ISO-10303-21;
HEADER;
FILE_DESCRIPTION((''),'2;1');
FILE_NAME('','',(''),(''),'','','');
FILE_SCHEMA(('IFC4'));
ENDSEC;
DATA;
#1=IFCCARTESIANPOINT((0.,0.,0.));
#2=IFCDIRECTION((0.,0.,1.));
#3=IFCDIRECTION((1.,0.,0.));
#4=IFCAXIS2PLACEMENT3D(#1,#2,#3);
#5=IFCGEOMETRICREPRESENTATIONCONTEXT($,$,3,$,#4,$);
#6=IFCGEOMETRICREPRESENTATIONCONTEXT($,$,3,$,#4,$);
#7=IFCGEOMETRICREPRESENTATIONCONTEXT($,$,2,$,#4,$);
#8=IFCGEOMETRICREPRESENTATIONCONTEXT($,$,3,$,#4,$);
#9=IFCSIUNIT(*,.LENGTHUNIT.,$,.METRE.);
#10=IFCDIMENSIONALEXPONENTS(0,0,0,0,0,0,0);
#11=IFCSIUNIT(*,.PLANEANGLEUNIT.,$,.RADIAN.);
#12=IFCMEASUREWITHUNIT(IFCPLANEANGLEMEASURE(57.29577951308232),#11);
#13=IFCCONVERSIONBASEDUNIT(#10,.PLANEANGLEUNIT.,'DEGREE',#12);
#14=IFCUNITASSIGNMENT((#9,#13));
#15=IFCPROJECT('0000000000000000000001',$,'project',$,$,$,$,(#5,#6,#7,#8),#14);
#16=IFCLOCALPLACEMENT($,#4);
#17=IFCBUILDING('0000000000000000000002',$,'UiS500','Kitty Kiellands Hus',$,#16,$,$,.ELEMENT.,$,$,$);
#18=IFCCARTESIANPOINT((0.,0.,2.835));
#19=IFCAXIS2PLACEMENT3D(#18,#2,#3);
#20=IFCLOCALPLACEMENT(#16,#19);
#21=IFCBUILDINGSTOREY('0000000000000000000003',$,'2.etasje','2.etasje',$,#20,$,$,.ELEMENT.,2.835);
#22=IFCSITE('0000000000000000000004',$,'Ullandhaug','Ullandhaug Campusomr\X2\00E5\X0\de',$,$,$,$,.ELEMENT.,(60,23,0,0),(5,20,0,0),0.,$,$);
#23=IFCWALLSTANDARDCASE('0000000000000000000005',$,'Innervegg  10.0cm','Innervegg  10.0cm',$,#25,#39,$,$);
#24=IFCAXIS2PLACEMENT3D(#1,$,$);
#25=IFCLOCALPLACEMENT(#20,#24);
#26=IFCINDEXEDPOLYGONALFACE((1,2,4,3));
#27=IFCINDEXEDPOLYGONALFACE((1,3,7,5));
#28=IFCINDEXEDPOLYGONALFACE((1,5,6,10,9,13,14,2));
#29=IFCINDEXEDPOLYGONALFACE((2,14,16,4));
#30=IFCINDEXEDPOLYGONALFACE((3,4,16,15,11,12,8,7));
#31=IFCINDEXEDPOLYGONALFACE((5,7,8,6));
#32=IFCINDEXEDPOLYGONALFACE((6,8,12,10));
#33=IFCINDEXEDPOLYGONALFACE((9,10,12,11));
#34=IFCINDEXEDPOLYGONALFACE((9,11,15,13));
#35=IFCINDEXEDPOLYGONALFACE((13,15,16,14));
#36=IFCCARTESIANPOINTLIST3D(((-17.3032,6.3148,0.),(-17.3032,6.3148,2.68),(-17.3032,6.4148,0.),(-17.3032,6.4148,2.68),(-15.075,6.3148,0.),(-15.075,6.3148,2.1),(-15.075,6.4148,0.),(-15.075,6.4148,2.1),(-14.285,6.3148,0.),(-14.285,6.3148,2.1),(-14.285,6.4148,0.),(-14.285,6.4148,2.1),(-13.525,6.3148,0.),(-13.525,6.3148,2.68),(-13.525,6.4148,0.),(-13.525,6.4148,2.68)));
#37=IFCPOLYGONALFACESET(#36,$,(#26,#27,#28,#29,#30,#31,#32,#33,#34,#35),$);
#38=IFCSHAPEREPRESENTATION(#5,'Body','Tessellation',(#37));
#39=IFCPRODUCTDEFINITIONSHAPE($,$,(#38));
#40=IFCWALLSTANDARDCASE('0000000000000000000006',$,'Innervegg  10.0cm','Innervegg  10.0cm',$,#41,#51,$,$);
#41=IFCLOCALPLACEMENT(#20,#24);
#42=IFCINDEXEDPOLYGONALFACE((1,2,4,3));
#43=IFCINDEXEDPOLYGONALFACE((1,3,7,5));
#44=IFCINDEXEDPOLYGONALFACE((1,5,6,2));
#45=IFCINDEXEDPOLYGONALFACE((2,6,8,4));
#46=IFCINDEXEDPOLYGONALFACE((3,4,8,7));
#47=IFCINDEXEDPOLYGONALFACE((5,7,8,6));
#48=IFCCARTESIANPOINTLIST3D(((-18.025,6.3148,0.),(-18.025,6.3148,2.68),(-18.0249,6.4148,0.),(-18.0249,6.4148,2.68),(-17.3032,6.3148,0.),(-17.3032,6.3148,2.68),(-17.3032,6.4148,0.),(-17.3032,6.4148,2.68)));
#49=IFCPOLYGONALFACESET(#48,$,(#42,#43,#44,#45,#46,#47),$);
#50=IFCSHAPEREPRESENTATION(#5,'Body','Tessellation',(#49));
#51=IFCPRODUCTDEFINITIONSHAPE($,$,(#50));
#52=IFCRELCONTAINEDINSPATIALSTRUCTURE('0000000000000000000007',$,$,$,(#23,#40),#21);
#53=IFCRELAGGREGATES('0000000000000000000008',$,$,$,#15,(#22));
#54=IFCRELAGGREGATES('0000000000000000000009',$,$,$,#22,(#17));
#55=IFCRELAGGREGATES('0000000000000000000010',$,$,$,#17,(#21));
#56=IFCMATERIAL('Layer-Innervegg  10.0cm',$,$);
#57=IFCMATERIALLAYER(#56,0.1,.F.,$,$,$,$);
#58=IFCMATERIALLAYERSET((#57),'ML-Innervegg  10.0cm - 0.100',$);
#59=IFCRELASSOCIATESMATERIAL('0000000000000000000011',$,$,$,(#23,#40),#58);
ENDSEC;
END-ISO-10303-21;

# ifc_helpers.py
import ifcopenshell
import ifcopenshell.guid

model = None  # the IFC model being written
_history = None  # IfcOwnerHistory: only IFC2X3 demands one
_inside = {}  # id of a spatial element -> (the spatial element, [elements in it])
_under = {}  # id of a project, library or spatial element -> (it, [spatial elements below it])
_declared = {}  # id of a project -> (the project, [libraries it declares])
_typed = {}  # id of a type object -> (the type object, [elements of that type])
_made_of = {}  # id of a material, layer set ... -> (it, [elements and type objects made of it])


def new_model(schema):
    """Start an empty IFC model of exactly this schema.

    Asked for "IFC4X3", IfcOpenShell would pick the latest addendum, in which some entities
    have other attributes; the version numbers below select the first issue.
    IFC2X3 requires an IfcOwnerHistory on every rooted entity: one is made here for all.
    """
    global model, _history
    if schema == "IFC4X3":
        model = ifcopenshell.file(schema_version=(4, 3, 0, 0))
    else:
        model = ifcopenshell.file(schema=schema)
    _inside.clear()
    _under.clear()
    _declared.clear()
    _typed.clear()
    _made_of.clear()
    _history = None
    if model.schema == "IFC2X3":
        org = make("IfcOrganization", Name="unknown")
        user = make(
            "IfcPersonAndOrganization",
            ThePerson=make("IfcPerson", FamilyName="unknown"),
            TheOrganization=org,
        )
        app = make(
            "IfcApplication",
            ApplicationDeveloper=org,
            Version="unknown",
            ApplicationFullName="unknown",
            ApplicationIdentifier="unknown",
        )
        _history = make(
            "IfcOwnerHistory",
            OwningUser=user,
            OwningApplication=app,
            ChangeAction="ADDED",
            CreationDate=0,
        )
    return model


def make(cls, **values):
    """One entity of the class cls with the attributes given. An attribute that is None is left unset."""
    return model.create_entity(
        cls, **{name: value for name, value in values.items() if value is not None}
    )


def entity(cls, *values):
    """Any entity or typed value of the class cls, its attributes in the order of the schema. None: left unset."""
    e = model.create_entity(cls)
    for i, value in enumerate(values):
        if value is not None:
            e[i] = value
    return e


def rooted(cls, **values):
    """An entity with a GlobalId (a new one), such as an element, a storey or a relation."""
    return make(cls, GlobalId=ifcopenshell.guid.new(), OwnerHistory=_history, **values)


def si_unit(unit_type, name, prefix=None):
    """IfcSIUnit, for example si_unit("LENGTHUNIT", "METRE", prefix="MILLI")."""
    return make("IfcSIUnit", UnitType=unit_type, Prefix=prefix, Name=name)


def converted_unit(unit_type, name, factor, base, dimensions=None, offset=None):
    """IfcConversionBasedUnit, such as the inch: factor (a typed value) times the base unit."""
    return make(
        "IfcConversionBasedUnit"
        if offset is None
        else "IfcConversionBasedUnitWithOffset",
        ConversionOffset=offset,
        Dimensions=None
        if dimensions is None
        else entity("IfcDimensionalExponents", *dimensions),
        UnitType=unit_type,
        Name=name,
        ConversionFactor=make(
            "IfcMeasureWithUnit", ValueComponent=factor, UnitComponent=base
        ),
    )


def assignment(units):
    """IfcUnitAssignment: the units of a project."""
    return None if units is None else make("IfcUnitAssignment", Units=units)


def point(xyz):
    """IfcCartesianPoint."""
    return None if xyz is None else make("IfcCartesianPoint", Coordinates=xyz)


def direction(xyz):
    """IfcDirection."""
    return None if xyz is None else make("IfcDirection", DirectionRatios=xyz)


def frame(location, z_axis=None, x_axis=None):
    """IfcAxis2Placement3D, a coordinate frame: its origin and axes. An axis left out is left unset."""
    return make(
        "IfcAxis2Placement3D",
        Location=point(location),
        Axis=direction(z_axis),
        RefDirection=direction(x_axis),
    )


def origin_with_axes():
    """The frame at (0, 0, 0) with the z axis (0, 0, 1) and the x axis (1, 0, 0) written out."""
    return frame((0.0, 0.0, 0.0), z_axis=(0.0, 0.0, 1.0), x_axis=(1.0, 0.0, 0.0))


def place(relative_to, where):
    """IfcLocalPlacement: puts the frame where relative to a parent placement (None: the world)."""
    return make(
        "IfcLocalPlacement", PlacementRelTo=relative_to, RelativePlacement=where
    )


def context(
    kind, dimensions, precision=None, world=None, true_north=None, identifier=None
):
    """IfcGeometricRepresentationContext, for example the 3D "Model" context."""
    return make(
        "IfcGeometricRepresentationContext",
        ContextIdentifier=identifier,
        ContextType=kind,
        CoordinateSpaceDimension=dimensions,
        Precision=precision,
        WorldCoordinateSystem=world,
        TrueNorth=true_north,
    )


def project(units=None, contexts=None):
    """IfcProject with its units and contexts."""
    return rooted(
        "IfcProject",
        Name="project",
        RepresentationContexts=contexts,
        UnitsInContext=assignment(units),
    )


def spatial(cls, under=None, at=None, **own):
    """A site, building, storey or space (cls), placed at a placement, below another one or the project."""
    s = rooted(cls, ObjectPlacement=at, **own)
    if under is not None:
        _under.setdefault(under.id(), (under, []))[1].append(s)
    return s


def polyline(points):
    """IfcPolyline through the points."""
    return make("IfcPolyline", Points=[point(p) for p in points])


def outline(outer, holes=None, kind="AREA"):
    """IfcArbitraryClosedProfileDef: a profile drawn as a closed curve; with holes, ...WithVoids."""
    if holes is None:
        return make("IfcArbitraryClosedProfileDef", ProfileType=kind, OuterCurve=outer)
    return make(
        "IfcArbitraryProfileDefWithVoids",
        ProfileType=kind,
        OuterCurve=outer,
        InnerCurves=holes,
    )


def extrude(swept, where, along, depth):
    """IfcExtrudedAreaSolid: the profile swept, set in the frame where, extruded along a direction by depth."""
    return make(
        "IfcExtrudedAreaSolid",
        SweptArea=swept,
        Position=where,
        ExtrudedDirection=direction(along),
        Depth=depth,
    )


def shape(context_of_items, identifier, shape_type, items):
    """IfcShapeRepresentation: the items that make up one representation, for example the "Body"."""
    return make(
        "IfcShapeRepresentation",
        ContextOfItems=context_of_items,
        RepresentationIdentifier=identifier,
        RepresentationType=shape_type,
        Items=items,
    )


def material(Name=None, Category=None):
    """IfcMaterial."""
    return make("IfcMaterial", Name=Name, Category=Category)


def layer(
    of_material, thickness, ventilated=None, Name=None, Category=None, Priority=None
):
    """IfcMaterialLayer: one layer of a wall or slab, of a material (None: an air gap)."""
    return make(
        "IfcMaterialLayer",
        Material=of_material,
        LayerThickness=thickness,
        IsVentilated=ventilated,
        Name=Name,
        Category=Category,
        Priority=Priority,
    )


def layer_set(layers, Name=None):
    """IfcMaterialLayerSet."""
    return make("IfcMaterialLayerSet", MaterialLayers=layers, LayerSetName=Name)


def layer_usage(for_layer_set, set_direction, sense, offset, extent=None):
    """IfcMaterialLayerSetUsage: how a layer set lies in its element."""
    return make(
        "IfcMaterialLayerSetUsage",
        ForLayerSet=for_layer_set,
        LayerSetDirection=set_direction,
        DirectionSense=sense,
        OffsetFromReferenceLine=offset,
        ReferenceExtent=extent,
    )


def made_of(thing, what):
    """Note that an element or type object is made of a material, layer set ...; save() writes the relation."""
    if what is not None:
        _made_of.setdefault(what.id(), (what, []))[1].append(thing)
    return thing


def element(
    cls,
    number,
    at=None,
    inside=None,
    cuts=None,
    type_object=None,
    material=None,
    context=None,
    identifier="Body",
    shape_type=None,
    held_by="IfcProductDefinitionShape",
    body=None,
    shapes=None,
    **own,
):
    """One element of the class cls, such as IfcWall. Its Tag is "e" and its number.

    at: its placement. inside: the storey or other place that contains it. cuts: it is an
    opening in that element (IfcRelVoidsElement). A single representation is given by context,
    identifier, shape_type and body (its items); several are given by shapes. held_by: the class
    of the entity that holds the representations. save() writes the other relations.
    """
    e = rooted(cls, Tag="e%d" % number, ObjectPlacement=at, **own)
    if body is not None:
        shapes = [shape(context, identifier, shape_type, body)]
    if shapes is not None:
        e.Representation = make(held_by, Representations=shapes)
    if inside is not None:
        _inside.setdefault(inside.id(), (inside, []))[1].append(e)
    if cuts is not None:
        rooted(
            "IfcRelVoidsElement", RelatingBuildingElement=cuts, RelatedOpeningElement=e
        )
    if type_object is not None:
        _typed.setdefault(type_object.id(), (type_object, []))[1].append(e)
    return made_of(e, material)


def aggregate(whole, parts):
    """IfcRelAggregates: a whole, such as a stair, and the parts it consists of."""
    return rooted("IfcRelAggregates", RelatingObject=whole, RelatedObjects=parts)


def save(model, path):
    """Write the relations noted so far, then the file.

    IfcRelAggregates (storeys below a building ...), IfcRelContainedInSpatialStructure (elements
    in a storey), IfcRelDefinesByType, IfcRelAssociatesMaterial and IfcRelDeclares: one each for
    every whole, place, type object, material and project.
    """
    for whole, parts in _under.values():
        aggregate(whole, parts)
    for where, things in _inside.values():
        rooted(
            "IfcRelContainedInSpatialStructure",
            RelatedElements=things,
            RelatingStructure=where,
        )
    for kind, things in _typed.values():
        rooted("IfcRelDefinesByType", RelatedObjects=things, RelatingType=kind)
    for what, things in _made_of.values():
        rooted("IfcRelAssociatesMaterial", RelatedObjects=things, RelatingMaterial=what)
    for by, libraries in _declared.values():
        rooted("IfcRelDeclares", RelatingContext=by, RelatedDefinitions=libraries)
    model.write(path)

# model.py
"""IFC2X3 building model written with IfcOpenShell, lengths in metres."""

from ifc_helpers import new_model, entity, si_unit, converted_unit, frame, origin_with_axes, place, context, project, spatial, polyline, outline, extrude, material, layer, layer_set, layer_usage, element, save


model = new_model("IFC2X3")

# Units and contexts
context_of_model_1 = context(None, 3, world=origin_with_axes())
context_of_model_2 = context(None, 3, world=origin_with_axes())
context_of_model_3 = context(None, 2, world=origin_with_axes())
context_of_model_4 = context(None, 3, world=origin_with_axes())
ifc_project = project(units=[si_unit("LENGTHUNIT", "METRE"), converted_unit("PLANEANGLEUNIT", "DEGREE", entity("IfcPlaneAngleMeasure", 57.29577951308232), si_unit("PLANEANGLEUNIT", "RADIAN"), dimensions=[0, 0, 0, 0, 0, 0, 0])], contexts=[context_of_model_1, context_of_model_2, context_of_model_3, context_of_model_4])

# Site, building, storey
site = spatial("IfcSite", under=ifc_project, Name="Ullandhaug", Description="Ullandhaug Campusområde", CompositionType="ELEMENT", RefLatitude=(60, 23, 0, 0), RefLongitude=(5, 20, 0, 0), RefElevation=0.0)
building_placement = place(None, origin_with_axes())
building = spatial("IfcBuilding", under=site, at=building_placement, Name="UiS500", Description="Kitty Kiellands Hus", CompositionType="ELEMENT")
storey_placement = place(building_placement, frame((0.0, 0.0, 2.835), z_axis=(0.0, 0.0, 1.0), x_axis=(1.0, 0.0, 0.0)))
storey = spatial("IfcBuildingStorey", under=building, at=storey_placement, Name="2.etasje", Description="2.etasje", CompositionType="ELEMENT", Elevation=2.835)

# Shared definitions
ifc_material_1 = material(Name="Layer-Innervegg  10.0cm")
ifc_layer_1 = layer(ifc_material_1, 0.1, ventilated=False)
ifc_layer_set_1 = layer_set([ifc_layer_1], Name="ML-Innervegg  10.0cm - 0.100")
ifc_layer_usage_1 = layer_usage(ifc_layer_set_1, "AXIS2", "POSITIVE", 0.0)

# Wall, opening
wall_1_placement = place(storey_placement, frame((-13.525, 6.4148, 0.0), z_axis=(0.0, 0.0, 1.0), x_axis=(-1.0, 0.000006, 0.0)))
wall_1 = element("IfcWallStandardCase", 1, at=wall_1_placement, inside=storey, material=ifc_layer_usage_1, Name="Innervegg  10.0cm", Description="Innervegg  10.0cm", context=context_of_model_1, shape_type="SweptSolid", body=[
    extrude(outline(polyline([(0.0, 0.0), (3.7782, 0.0), (3.7782, 0.1), (0.0, 0.1), (0.0, 0.0)])), frame((0.0, 0.0, 0.0), z_axis=(0.0, 0.0, 1.0), x_axis=(1.0, 0.0, 0.0)), (0.0, 0.0, 1.0), 2.68),
])
opening_1_placement = place(wall_1_placement, frame((0.76, 0.1, 0.0), z_axis=(0.0, 0.0, 1.0), x_axis=(1.0, 0.0, 0.0)))
element("IfcOpeningElement", 2, at=opening_1_placement, cuts=wall_1, context=context_of_model_1, shape_type="SweptSolid", body=[
    extrude(outline(polyline([(0.0, 0.0), (2.1, 0.0), (2.1, 0.79), (0.0, 0.79), (0.0, 0.0)])), frame((0.0, 0.0, 0.0), z_axis=(-0.000006, 1.0, 0.0), x_axis=(0.0, 0.0, 1.0)), (0.0, -0.000006, -1.0), 0.1),
])

# Wall
wall_2_placement = place(storey_placement, frame((-17.3032, 6.4148, 0.0), z_axis=(0.0, 0.0, 1.0), x_axis=(-1.0, 0.000006, 0.0)))
element("IfcWallStandardCase", 3, at=wall_2_placement, inside=storey, material=ifc_layer_usage_1, Name="Innervegg  10.0cm", Description="Innervegg  10.0cm", context=context_of_model_1, shape_type="SweptSolid", body=[
    extrude(outline(polyline([(0.0, 0.0), (0.7217, 0.0), (0.7218, 0.1), (0.0, 0.1), (0.0, 0.0)])), frame((0.0, 0.0, 0.0), z_axis=(0.0, 0.0, 1.0), x_axis=(1.0, 0.0, 0.0)), (0.0, 0.0, 1.0), 2.68),
])

save(model, "model.ifc")
